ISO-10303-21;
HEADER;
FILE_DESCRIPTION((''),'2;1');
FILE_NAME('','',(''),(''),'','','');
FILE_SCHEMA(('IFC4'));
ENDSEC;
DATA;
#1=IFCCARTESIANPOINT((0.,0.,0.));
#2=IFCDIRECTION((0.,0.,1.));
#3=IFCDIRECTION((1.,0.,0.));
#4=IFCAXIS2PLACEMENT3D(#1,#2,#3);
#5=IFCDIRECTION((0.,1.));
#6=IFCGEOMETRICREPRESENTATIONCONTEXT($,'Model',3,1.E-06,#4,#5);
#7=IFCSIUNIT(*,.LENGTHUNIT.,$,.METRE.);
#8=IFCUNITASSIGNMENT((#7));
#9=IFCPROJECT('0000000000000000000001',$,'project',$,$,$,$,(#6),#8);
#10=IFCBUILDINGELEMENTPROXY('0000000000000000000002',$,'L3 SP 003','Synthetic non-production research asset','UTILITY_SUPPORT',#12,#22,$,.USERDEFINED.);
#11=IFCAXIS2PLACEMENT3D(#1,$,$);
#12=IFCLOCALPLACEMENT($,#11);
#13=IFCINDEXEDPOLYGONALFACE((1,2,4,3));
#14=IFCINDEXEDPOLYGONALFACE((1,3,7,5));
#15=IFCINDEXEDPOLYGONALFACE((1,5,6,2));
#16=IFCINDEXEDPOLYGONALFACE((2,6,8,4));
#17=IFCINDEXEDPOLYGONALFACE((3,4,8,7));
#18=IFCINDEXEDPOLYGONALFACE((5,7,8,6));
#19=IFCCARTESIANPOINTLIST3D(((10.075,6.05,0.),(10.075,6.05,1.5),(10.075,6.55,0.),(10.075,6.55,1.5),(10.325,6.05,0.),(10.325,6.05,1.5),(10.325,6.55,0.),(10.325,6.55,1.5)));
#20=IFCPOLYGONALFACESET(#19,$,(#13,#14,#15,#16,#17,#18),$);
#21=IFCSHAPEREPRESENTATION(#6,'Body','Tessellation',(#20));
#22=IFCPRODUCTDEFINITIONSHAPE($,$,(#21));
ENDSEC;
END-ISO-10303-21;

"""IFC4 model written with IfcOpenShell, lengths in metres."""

from ifc_helpers import new_model, si_unit, direction, frame, origin_with_axes, origin_2d_with_axis, place, context, project, rectangle, extrude, element, save


model = new_model("IFC4")

# Units and contexts
model_context = context("Model", 3, precision=1e-06, world=origin_with_axes(), true_north=direction((0.0, 1.0)))
ifc_project = project(units=[si_unit("LENGTHUNIT", "METRE")], contexts=[model_context])

# Building element proxy
proxy_placement = place(None, frame((10.2, 6.3, 0.0), z_axis=(0.0, 0.0, 1.0), x_axis=(1.0, 0.0, 0.0)))
element("IfcBuildingElementProxy", 1, at=proxy_placement, Name="L3 SP 003", Description="Synthetic non-production research asset", ObjectType="UTILITY_SUPPORT", PredefinedType="USERDEFINED", context=model_context, shape_type="SweptSolid", body=[
    extrude(rectangle(XDim=0.25, YDim=0.5, at=origin_2d_with_axis()), origin_with_axes(), (0.0, 0.0, 1.0), 1.5),
])

save(model, "model.ifc")
